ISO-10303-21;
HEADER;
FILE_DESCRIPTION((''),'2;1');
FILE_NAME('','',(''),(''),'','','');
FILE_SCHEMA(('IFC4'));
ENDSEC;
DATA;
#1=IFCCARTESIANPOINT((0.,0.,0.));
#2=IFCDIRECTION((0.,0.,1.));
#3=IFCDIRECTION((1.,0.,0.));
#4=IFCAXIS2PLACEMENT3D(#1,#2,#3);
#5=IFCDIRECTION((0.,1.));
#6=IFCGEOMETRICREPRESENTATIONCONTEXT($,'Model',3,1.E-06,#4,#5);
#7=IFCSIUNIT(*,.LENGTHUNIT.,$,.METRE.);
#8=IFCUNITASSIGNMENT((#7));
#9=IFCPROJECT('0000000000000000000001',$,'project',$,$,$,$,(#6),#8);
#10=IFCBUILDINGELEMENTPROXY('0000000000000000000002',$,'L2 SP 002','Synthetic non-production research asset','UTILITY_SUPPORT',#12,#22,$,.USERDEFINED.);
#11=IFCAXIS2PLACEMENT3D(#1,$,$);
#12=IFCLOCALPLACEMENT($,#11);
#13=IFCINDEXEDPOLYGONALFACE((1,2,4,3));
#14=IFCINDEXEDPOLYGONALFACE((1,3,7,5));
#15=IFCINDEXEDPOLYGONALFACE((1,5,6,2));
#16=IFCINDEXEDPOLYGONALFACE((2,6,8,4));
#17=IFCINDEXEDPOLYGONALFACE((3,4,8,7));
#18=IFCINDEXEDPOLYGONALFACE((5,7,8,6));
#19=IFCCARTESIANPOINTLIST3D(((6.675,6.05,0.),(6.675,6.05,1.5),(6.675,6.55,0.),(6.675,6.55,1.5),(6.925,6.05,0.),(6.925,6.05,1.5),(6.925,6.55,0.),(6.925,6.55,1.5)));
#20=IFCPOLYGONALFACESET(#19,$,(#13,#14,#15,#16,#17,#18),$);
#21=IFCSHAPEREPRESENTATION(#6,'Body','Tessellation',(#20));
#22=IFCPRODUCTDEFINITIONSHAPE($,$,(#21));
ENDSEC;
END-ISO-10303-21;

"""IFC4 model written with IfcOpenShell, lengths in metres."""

from ifc_helpers import new_model, si_unit, direction, frame, origin_with_axes, origin_2d_with_axis, place, context, project, rectangle, extrude, element, save


model = new_model("IFC4")

# Units and contexts
model_context = context("Model", 3, precision=1e-06, world=origin_with_axes(), true_north=direction((0.0, 1.0)))
ifc_project = project(units=[si_unit("LENGTHUNIT", "METRE")], contexts=[model_context])

# Building element proxy
proxy_placement = place(None, frame((6.8, 6.3, 0.0), z_axis=(0.0, 0.0, 1.0), x_axis=(1.0, 0.0, 0.0)))
element("IfcBuildingElementProxy", 1, at=proxy_placement, Name="L2 SP 002", Description="Synthetic non-production research asset", ObjectType="UTILITY_SUPPORT", PredefinedType="USERDEFINED", context=model_context, shape_type="SweptSolid", body=[
    extrude(rectangle(XDim=0.25, YDim=0.5, at=origin_2d_with_axis()), origin_with_axes(), (0.0, 0.0, 1.0), 1.5),
])

save(model, "model.ifc")
